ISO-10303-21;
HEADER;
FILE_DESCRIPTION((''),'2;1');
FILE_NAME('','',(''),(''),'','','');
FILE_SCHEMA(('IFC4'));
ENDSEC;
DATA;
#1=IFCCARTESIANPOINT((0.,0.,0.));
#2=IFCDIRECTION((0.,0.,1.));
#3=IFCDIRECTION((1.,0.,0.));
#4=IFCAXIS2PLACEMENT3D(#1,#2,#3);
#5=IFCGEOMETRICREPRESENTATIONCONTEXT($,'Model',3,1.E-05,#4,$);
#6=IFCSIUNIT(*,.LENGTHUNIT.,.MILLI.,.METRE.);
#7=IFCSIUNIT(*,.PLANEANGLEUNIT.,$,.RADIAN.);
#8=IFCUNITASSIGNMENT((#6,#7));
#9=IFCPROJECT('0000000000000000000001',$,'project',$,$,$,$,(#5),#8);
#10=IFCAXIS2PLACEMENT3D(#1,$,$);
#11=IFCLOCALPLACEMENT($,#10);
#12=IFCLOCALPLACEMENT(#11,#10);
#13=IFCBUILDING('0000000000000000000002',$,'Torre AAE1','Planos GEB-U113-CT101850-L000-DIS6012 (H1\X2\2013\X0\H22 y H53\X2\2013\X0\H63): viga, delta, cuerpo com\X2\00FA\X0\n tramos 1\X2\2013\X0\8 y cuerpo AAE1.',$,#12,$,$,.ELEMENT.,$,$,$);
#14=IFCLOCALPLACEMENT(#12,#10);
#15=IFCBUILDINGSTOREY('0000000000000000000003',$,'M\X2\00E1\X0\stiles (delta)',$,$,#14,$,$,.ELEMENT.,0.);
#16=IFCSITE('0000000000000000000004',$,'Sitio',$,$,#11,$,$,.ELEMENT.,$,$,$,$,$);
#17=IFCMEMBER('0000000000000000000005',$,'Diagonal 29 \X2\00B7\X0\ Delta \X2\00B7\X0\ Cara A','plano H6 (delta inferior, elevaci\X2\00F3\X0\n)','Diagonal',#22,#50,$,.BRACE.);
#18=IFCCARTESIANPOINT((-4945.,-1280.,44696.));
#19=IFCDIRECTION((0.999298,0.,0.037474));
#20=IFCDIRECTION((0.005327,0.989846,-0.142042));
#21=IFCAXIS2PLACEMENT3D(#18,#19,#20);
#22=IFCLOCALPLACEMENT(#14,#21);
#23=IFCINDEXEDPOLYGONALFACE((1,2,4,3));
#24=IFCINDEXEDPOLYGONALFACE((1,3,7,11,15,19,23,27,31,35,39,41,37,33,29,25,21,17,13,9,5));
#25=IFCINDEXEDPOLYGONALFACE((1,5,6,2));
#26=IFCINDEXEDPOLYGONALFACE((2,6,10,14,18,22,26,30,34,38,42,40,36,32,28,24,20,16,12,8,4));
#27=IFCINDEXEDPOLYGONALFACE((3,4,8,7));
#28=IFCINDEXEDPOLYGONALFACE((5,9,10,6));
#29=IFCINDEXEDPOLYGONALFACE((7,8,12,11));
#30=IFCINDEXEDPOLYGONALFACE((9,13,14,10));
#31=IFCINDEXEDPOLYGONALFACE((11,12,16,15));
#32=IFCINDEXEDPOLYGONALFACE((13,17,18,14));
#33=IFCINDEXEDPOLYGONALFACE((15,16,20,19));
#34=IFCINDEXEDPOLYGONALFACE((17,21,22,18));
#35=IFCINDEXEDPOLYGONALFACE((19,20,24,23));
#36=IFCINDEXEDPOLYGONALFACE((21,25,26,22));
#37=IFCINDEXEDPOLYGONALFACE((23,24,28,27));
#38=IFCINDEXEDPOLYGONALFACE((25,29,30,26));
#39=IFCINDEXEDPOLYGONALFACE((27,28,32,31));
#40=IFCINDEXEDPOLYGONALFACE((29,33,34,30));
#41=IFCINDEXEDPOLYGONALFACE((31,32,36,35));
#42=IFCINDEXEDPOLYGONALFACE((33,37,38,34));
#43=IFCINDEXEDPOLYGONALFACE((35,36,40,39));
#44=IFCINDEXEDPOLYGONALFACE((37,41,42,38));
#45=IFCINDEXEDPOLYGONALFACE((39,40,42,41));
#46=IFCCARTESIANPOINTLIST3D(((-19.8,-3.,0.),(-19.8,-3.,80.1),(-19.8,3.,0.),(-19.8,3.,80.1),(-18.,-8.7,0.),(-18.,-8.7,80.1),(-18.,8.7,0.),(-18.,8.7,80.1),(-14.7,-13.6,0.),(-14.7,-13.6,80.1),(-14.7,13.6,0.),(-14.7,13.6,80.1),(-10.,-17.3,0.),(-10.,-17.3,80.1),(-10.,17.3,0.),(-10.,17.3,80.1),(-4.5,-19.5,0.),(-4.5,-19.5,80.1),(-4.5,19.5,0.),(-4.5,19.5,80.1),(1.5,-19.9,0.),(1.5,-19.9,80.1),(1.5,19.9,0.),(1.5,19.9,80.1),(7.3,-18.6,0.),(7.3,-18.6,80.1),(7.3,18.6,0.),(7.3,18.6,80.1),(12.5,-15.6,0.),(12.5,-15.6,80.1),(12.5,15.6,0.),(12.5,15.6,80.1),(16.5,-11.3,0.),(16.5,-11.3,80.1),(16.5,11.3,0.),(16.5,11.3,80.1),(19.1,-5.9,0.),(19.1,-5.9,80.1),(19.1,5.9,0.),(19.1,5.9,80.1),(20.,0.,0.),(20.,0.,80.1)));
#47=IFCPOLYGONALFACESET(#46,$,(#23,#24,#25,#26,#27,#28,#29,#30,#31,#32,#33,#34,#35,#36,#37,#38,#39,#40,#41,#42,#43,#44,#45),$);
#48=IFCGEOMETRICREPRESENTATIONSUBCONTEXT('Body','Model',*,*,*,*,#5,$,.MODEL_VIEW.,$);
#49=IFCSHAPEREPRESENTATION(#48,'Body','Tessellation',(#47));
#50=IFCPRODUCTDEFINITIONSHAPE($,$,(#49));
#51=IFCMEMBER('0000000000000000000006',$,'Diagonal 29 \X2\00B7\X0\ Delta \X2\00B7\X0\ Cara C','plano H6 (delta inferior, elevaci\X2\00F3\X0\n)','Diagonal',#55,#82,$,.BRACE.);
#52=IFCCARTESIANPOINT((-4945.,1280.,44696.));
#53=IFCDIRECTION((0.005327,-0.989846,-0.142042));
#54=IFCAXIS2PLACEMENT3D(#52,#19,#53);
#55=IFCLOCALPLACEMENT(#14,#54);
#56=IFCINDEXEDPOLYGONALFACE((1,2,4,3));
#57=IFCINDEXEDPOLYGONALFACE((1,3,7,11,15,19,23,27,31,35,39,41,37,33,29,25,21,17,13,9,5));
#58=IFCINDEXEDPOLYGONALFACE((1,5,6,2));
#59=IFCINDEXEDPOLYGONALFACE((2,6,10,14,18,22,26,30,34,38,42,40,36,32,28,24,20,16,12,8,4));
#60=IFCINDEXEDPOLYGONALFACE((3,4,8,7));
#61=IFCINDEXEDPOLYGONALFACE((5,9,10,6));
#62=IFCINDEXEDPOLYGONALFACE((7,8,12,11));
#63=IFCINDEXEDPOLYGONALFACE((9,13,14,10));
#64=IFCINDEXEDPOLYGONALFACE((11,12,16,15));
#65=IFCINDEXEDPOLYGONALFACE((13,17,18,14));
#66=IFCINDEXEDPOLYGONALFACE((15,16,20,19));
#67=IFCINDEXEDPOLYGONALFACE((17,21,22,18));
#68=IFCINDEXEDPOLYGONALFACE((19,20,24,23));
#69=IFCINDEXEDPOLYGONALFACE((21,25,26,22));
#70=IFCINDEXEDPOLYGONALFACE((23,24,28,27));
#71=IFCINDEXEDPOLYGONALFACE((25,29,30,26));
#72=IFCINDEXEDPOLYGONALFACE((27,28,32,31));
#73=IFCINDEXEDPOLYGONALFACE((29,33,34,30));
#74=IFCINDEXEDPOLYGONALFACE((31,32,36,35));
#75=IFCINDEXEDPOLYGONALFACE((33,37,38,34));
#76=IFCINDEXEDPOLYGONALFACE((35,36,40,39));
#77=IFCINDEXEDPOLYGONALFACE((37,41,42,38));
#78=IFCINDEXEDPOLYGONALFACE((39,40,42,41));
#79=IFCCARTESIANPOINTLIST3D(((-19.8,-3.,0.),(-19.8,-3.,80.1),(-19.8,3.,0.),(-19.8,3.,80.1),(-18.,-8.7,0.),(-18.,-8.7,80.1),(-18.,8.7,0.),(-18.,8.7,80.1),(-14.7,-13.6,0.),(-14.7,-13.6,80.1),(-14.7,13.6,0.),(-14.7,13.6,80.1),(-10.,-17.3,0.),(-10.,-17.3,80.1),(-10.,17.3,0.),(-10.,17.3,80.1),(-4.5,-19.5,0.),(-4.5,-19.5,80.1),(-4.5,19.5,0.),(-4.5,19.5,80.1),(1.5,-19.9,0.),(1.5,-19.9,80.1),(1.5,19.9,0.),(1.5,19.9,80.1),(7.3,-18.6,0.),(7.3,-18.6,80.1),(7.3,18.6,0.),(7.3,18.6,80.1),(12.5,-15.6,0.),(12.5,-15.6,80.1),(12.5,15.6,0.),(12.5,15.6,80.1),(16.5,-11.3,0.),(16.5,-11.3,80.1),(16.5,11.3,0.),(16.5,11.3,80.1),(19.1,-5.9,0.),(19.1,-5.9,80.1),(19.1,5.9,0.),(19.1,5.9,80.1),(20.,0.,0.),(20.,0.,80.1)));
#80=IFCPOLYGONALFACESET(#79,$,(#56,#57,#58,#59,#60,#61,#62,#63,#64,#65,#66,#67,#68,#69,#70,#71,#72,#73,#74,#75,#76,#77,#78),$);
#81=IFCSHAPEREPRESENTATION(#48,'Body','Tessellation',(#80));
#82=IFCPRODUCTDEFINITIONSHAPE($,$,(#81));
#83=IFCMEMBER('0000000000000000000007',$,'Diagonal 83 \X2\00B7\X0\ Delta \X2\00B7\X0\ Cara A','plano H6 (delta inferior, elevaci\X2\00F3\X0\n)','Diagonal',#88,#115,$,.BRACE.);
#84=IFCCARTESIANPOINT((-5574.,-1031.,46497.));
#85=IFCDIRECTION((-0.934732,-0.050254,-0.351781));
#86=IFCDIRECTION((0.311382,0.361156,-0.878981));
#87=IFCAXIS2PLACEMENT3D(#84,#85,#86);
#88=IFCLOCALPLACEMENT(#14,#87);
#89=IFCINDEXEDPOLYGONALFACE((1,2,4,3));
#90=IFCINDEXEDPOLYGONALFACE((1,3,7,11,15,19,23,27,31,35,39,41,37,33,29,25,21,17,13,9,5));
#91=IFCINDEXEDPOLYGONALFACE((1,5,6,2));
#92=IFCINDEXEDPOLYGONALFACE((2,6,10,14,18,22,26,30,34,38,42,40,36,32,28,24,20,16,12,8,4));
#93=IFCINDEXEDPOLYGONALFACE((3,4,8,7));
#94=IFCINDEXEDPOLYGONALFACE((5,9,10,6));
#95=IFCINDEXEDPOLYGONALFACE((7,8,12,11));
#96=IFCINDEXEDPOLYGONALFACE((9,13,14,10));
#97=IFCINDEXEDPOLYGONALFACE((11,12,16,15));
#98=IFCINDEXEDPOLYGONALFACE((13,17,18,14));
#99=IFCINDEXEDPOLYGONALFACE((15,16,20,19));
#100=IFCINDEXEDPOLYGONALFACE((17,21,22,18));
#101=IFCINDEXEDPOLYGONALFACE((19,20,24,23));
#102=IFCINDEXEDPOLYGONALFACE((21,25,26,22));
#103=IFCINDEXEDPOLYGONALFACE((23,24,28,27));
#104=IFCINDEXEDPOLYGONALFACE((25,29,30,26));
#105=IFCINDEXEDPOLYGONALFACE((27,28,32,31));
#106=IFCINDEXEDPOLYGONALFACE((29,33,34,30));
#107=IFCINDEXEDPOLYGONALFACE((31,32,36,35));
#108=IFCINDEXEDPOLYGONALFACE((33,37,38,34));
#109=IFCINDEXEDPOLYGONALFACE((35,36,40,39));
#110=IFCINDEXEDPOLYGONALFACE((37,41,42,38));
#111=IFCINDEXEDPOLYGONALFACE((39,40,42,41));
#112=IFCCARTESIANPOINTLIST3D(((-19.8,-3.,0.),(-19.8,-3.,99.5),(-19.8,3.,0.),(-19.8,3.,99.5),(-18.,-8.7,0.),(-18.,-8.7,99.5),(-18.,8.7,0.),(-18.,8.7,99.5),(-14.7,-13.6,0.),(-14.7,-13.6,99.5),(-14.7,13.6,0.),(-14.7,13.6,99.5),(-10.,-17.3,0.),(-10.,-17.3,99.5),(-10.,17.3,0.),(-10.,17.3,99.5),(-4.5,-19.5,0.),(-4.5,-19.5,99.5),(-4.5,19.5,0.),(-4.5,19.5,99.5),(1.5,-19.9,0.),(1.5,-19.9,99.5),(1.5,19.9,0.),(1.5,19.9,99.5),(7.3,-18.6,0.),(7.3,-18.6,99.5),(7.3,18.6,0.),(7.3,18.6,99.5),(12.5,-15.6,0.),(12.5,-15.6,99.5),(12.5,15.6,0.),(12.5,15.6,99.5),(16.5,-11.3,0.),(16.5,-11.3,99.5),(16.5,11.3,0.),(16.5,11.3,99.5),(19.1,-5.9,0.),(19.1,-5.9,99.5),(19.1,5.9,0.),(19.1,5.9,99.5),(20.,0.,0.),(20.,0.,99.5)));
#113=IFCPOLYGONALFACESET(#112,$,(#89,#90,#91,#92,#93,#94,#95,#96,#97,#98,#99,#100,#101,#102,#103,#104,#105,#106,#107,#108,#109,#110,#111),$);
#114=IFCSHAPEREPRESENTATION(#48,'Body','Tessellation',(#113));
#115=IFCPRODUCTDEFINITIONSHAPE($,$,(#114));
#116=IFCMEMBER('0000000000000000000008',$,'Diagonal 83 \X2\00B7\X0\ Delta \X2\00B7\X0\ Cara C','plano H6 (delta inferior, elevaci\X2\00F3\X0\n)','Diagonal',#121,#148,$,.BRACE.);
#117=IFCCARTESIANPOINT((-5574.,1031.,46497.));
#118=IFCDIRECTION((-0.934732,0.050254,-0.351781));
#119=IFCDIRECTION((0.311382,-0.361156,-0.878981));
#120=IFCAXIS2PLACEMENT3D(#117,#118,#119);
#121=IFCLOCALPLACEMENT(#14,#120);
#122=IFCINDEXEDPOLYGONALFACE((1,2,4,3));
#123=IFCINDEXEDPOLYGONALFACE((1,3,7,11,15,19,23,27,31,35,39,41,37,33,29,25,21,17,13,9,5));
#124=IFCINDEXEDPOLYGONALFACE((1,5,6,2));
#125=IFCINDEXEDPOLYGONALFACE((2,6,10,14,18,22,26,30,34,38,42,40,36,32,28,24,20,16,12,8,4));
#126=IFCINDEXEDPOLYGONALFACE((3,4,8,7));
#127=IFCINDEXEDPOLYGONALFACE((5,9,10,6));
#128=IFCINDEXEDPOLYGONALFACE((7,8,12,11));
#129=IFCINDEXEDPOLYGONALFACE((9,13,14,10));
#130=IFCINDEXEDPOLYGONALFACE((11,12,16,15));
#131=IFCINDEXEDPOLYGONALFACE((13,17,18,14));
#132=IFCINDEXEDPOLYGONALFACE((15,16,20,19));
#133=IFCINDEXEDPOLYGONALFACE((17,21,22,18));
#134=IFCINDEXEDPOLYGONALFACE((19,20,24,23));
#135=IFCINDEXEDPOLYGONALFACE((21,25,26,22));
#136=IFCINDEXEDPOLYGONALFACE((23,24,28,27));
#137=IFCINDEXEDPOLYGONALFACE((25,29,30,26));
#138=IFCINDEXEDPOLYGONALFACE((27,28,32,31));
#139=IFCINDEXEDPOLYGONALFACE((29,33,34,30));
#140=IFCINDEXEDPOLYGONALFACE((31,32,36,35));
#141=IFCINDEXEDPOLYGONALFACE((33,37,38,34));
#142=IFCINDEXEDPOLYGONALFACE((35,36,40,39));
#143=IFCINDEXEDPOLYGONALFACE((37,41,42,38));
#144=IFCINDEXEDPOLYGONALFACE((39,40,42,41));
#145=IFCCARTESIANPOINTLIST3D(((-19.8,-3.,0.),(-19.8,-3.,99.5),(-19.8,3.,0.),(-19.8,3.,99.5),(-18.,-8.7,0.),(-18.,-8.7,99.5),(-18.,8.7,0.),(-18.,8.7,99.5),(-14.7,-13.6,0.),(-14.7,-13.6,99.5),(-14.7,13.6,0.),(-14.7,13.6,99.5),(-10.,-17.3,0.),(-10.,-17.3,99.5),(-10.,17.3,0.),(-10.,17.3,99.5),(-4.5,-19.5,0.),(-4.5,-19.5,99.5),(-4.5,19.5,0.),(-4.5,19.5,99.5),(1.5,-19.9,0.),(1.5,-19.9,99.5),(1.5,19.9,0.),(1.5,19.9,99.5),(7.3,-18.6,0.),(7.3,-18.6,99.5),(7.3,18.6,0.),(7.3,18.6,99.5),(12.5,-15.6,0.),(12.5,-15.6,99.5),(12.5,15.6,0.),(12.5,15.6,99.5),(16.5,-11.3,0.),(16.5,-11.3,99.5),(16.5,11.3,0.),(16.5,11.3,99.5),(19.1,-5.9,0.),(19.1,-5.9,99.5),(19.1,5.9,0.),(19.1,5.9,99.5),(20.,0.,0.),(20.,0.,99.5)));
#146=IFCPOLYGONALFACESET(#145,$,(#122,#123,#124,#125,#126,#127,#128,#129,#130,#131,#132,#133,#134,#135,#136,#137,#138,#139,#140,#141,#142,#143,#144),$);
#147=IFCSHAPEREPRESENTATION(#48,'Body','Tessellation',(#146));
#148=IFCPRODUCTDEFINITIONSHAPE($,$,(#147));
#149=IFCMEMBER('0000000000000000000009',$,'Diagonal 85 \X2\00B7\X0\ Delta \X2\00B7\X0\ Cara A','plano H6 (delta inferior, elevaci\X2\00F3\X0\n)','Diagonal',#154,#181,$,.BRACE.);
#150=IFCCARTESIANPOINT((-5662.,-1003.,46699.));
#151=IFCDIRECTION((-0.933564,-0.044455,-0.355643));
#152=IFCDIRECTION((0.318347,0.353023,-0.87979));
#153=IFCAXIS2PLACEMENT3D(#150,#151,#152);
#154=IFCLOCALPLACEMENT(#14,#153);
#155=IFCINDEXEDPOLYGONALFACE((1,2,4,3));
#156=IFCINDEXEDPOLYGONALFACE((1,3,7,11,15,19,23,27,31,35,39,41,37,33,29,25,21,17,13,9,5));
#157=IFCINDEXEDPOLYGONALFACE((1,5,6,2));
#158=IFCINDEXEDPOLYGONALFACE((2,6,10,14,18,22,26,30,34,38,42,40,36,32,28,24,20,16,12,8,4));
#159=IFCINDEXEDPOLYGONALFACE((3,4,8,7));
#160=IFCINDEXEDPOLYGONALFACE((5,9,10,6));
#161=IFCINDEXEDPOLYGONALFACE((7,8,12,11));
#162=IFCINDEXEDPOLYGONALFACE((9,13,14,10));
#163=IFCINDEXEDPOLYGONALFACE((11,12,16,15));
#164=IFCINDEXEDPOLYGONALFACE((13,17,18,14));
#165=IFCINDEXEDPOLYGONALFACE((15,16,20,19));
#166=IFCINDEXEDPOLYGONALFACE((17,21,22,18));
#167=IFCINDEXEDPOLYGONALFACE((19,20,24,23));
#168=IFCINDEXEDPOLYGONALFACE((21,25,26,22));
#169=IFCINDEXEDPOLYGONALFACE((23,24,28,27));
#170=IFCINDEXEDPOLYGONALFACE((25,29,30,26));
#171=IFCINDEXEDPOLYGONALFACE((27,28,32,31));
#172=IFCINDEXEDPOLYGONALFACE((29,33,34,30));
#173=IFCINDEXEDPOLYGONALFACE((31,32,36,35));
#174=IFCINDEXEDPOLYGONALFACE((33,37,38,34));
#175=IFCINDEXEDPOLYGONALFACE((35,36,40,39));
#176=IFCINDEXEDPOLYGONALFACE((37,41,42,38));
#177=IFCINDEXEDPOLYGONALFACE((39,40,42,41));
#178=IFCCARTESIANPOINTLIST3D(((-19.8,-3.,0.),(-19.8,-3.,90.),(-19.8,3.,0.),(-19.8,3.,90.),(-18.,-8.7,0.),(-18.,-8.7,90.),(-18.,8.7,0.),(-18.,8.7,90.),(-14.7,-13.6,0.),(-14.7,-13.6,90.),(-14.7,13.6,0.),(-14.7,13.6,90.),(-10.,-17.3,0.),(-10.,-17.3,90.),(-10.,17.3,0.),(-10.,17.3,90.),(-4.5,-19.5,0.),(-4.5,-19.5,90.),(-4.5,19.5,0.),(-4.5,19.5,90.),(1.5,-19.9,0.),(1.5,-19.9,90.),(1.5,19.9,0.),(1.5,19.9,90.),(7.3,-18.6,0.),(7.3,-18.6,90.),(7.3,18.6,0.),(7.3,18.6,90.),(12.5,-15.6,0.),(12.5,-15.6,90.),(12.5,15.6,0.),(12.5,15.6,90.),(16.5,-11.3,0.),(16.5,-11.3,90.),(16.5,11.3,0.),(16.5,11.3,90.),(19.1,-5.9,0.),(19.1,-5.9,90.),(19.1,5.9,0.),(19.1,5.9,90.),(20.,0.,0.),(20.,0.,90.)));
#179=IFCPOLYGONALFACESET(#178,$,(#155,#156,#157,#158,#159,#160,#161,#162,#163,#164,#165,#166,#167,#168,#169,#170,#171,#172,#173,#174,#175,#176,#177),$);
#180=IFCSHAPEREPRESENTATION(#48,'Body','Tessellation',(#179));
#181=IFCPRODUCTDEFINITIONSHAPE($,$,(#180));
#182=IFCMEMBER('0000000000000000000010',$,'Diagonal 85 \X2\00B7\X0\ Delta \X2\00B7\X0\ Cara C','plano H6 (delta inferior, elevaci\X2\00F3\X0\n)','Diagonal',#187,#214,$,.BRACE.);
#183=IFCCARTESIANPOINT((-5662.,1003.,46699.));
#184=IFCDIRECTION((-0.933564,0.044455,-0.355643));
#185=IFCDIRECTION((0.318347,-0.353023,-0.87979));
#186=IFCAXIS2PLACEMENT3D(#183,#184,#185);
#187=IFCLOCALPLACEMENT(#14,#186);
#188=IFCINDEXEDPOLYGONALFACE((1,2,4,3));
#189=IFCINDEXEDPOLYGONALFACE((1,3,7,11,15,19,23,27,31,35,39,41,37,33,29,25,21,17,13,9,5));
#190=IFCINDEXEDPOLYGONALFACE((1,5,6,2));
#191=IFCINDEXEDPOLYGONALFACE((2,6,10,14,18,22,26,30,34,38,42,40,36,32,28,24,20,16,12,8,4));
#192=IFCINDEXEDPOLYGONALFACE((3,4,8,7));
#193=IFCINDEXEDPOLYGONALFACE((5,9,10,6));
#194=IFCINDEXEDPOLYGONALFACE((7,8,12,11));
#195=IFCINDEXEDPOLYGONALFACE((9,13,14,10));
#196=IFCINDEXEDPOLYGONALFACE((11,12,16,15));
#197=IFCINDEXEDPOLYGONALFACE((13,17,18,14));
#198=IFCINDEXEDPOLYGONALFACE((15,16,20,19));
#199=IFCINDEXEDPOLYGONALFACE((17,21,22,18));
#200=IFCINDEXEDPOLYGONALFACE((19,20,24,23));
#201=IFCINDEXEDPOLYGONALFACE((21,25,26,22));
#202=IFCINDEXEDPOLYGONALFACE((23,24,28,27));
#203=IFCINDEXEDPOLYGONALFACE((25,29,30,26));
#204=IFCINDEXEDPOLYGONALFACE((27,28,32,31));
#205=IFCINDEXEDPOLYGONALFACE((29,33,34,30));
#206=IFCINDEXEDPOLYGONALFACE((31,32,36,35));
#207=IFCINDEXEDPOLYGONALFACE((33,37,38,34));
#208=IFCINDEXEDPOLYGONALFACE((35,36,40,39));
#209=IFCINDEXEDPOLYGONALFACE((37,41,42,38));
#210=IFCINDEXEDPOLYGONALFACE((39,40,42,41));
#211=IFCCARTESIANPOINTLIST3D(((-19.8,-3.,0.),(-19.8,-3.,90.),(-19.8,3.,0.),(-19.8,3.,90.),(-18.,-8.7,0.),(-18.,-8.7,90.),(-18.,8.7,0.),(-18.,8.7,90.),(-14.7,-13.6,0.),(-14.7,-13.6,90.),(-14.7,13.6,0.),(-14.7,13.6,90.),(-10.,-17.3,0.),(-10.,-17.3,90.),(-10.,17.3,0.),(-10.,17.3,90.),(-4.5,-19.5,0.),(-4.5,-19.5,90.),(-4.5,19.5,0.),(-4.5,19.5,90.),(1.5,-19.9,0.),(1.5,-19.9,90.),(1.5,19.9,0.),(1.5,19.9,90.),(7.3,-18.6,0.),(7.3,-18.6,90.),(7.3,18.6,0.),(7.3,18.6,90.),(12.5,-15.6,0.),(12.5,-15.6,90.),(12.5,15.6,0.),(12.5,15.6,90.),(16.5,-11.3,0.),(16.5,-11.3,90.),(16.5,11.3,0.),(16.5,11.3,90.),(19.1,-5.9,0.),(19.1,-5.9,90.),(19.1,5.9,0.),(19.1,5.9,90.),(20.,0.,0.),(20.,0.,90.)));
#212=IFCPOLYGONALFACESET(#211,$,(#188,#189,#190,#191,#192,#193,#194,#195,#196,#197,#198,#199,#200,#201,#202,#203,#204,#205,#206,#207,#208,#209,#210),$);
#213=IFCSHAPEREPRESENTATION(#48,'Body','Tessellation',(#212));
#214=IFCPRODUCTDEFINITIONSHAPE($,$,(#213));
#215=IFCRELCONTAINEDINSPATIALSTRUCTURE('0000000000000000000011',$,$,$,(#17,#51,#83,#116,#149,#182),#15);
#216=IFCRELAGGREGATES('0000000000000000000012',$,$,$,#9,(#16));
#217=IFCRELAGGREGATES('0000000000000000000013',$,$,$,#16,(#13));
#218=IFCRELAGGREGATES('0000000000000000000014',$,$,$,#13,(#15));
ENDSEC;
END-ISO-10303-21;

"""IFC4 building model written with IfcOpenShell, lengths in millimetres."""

from ifc_helpers import new_model, si_unit, frame, origin, origin_with_axes, place, context, subcontext, project, spatial, circle, extrude, element, save


model = new_model("IFC4")

# Units and contexts
model_context = context("Model", 3, precision=1e-05, world=origin_with_axes())
body_context = subcontext(model_context, "Body", "Model", "MODEL_VIEW")
ifc_project = project(units=[si_unit("LENGTHUNIT", "METRE", prefix="MILLI"), si_unit("PLANEANGLEUNIT", "RADIAN")], contexts=[model_context])

# Site, building, storey
site_placement = place(None, origin())
site = spatial("IfcSite", under=ifc_project, at=site_placement, Name="Sitio", CompositionType="ELEMENT")
building_placement = place(site_placement, origin())
building = spatial("IfcBuilding", under=site, at=building_placement, Name="Torre AAE1", Description="Planos GEB-U113-CT101850-L000-DIS6012 (H1–H22 y H53–H63): viga, delta, cuerpo común tramos 1–8 y cuerpo AAE1.", CompositionType="ELEMENT")
storey_placement = place(building_placement, origin())
storey = spatial("IfcBuildingStorey", under=building, at=storey_placement, Name="Mástiles (delta)", CompositionType="ELEMENT", Elevation=0.0)

# Members
for number, where, z_axis, x_axis, name in (
    (1, (-4945.0, -1280.0, 44696.0), (0.999298, 0.0, 0.037474), (0.005327, 0.989846, -0.142042), "Diagonal 29 · Delta · Cara A"),
    (2, (-4945.0, 1280.0, 44696.0), (0.999298, 0.0, 0.037474), (0.005327, -0.989846, -0.142042), "Diagonal 29 · Delta · Cara C"),
):
    element("IfcMember", number, at=place(storey_placement, frame(where, z_axis=z_axis, x_axis=x_axis)), inside=storey, Name=name, Description="plano H6 (delta inferior, elevación)", ObjectType="Diagonal", PredefinedType="BRACE", context=body_context, shape_type="SweptSolid", body=[
        extrude(circle(Radius=20.0), None, (0.0, 0.0, 1.0), 80.1),
    ])
for number, where, z_axis, x_axis, name in (
    (3, (-5574.0, -1031.0, 46497.0), (-0.934732, -0.050254, -0.351781), (0.311382, 0.361156, -0.878981), "Diagonal 83 · Delta · Cara A"),
    (4, (-5574.0, 1031.0, 46497.0), (-0.934732, 0.050254, -0.351781), (0.311382, -0.361156, -0.878981), "Diagonal 83 · Delta · Cara C"),
):
    element("IfcMember", number, at=place(storey_placement, frame(where, z_axis=z_axis, x_axis=x_axis)), inside=storey, Name=name, Description="plano H6 (delta inferior, elevación)", ObjectType="Diagonal", PredefinedType="BRACE", context=body_context, shape_type="SweptSolid", body=[
        extrude(circle(Radius=20.0), None, (0.0, 0.0, 1.0), 99.5),
    ])
for number, where, z_axis, x_axis, name in (
    (5, (-5662.0, -1003.0, 46699.0), (-0.933564, -0.044455, -0.355643), (0.318347, 0.353023, -0.87979), "Diagonal 85 · Delta · Cara A"),
    (6, (-5662.0, 1003.0, 46699.0), (-0.933564, 0.044455, -0.355643), (0.318347, -0.353023, -0.87979), "Diagonal 85 · Delta · Cara C"),
):
    element("IfcMember", number, at=place(storey_placement, frame(where, z_axis=z_axis, x_axis=x_axis)), inside=storey, Name=name, Description="plano H6 (delta inferior, elevación)", ObjectType="Diagonal", PredefinedType="BRACE", context=body_context, shape_type="SweptSolid", body=[
        extrude(circle(Radius=20.0), None, (0.0, 0.0, 1.0), 90.0),
    ])

save(model, "model.ifc")
